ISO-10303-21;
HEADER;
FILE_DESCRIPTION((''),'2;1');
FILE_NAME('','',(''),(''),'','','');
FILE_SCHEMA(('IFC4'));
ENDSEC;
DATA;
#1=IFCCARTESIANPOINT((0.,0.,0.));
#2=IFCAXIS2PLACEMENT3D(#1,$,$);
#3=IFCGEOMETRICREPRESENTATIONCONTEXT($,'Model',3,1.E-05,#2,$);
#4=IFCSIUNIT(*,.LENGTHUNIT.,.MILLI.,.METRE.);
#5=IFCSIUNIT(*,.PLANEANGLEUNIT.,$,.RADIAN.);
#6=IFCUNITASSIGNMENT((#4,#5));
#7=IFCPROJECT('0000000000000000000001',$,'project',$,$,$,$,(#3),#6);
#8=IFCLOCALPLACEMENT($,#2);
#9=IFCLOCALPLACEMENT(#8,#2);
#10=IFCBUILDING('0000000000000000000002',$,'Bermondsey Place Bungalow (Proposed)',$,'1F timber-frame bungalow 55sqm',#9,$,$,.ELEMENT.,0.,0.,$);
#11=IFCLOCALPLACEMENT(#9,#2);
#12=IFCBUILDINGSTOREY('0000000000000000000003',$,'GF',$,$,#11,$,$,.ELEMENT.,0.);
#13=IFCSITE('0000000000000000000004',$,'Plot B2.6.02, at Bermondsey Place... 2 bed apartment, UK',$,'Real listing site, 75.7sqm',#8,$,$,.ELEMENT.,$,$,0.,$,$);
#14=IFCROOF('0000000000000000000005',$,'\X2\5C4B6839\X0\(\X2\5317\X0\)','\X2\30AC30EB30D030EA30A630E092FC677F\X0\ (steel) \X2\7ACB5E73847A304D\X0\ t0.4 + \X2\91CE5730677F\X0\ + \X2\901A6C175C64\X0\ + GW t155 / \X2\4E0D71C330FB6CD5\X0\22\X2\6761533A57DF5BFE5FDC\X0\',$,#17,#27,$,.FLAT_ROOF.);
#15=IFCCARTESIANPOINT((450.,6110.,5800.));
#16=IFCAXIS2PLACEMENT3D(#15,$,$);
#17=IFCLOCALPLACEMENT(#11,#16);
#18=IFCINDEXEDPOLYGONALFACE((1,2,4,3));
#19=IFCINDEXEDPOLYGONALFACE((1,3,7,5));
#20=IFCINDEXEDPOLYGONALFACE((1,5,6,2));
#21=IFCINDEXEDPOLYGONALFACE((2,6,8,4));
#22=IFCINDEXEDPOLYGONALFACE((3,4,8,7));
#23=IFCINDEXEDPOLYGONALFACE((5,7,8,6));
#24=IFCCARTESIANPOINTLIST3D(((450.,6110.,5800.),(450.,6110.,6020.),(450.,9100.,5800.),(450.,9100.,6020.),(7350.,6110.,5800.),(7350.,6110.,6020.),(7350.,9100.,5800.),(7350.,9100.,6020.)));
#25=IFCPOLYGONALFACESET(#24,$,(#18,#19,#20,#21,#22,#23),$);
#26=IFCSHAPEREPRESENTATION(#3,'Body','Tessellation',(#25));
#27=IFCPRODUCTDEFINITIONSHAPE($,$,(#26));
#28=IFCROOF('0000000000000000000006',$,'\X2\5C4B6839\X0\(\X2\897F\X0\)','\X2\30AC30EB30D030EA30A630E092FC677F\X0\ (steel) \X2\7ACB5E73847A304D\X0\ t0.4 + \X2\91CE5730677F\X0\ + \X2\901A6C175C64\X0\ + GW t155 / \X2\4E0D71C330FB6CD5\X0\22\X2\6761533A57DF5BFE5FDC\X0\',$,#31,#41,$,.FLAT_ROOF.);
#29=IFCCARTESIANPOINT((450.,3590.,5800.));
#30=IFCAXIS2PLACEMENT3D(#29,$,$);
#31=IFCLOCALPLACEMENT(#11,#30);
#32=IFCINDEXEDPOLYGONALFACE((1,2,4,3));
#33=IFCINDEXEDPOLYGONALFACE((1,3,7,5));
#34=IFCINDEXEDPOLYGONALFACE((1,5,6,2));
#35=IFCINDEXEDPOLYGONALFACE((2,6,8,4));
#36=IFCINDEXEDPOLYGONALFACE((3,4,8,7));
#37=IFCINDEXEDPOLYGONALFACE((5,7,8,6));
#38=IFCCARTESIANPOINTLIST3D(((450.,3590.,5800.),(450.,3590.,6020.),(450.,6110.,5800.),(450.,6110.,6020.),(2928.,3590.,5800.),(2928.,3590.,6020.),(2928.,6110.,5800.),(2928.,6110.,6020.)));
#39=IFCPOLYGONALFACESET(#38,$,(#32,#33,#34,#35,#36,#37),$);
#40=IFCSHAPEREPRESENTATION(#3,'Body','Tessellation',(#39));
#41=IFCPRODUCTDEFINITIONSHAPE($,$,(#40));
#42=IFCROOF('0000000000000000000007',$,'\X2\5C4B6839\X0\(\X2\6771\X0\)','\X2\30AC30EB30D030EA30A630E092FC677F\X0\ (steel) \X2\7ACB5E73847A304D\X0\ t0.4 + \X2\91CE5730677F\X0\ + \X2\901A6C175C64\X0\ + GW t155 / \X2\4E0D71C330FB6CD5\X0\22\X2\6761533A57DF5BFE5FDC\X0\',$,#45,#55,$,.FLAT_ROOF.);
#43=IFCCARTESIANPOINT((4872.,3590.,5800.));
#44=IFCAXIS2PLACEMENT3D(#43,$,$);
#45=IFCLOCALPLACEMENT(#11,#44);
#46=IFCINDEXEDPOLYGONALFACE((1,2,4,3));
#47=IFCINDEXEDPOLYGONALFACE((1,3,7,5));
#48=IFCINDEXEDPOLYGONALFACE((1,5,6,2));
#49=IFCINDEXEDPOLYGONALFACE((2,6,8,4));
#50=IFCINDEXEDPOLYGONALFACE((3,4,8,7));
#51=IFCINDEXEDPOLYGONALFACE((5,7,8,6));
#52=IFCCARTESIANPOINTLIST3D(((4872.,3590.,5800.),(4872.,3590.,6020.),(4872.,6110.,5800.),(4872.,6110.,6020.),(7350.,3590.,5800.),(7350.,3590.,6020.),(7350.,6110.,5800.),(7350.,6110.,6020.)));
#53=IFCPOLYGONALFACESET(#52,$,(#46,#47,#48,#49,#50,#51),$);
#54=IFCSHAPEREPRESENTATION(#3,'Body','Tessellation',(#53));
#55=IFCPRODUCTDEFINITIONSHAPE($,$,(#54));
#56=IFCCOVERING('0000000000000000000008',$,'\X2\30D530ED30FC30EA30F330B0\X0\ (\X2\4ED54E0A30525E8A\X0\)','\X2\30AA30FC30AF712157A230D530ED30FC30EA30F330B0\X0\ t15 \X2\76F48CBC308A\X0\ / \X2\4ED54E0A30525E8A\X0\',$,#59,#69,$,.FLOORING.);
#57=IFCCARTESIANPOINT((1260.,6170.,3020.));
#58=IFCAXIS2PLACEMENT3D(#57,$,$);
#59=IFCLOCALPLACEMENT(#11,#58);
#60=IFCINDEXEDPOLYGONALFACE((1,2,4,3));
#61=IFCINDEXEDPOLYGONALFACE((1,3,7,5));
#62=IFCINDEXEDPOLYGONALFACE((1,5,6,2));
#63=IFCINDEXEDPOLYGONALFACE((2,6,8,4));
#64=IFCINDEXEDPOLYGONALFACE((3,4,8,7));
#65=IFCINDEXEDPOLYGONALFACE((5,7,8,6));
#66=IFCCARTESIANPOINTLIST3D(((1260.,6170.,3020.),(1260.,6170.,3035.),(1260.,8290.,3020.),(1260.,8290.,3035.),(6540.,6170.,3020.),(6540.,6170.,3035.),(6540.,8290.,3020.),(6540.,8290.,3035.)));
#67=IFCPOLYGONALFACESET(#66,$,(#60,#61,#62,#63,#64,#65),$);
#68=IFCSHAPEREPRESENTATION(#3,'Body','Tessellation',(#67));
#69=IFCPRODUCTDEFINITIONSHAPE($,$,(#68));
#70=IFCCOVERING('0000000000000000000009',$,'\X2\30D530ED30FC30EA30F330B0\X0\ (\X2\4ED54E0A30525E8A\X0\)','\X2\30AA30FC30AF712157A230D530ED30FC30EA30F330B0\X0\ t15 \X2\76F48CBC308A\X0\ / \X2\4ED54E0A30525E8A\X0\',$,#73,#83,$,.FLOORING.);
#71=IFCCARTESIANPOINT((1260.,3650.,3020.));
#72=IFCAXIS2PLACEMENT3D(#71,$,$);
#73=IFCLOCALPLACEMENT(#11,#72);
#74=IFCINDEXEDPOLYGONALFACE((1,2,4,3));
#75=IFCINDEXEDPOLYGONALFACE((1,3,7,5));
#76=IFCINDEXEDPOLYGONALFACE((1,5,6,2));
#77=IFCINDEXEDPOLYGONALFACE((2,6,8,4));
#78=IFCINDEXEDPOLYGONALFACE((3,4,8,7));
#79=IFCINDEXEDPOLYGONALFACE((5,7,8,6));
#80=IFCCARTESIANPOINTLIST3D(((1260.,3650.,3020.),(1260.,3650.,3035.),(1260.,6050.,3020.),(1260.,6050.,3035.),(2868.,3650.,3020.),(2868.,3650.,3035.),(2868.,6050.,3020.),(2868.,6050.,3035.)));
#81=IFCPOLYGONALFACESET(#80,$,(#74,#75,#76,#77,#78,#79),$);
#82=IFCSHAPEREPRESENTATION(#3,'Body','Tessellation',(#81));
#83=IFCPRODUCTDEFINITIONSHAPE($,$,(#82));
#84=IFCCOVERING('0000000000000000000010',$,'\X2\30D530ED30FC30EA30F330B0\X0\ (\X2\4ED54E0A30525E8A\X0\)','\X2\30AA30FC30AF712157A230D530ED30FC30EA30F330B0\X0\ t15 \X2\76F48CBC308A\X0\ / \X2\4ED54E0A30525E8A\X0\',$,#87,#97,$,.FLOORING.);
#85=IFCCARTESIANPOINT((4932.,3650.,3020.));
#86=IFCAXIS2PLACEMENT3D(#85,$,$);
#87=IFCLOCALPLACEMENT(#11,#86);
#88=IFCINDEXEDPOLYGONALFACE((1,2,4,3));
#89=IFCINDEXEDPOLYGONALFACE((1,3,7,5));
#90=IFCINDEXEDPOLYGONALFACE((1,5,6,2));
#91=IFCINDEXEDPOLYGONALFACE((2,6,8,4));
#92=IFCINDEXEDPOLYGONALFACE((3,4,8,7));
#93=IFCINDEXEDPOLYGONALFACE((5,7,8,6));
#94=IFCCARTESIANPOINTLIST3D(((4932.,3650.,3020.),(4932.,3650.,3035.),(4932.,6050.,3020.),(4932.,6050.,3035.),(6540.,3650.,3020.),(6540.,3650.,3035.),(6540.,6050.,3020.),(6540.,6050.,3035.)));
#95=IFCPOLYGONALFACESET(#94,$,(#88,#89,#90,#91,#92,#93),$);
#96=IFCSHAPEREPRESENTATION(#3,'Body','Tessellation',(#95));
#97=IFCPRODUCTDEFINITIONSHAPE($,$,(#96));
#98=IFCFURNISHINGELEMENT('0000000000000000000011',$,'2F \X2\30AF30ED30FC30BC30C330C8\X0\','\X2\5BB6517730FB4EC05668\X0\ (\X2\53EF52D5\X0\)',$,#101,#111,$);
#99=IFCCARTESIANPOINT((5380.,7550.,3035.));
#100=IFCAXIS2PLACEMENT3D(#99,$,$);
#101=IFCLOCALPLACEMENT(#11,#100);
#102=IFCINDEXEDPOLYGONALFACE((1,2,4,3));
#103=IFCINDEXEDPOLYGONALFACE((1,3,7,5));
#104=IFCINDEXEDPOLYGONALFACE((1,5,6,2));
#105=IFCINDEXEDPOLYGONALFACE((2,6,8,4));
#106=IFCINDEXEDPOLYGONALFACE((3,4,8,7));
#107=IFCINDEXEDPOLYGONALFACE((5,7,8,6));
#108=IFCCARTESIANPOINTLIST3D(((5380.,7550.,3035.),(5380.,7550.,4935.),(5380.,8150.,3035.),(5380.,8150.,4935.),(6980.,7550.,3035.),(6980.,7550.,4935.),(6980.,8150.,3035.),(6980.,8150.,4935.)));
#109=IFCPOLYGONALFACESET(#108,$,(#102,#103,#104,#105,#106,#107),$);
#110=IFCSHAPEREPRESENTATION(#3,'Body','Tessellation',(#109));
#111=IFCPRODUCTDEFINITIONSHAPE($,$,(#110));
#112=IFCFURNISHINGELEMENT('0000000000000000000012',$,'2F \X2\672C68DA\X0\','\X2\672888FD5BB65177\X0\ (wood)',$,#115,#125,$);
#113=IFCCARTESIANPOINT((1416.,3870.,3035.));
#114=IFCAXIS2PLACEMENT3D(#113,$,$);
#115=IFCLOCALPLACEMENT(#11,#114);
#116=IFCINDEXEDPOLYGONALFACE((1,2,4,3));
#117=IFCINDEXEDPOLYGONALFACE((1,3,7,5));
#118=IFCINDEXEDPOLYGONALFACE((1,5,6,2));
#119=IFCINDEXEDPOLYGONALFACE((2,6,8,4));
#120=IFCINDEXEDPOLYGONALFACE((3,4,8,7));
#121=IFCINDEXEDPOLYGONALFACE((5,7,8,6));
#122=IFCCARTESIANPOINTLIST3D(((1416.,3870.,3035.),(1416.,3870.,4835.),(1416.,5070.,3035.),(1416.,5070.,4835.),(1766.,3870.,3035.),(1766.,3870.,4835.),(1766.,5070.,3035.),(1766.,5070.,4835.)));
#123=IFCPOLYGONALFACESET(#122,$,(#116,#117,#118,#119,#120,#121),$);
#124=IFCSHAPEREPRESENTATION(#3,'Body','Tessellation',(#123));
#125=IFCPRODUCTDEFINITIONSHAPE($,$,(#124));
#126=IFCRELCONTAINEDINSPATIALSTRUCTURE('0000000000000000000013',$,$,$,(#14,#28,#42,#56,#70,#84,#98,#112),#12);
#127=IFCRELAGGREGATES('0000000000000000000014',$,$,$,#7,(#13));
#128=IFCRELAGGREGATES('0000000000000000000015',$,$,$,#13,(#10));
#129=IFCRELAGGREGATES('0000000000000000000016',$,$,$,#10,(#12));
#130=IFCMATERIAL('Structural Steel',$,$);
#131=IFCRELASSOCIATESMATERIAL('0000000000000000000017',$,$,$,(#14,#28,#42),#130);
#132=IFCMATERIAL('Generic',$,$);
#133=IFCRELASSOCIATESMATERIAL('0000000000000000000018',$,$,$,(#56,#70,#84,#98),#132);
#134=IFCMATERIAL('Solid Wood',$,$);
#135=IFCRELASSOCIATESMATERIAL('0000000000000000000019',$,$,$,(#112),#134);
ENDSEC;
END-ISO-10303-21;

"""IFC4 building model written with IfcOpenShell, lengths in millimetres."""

from ifc_helpers import new_model, si_unit, frame, frame_2d, origin, place, context, project, spatial, rectangle, extrude, material, element, save


model = new_model("IFC4")

# Units and contexts
model_context = context("Model", 3, precision=1e-05, world=origin())
ifc_project = project(units=[si_unit("LENGTHUNIT", "METRE", prefix="MILLI"), si_unit("PLANEANGLEUNIT", "RADIAN")], contexts=[model_context])

# Site, building, storey
site_placement = place(None, origin())
site = spatial("IfcSite", under=ifc_project, at=site_placement, Name="Plot B2.6.02, at Bermondsey Place... 2 bed apartment, UK", ObjectType="Real listing site, 75.7sqm", CompositionType="ELEMENT", RefElevation=0.0)
building_placement = place(site_placement, origin())
building = spatial("IfcBuilding", under=site, at=building_placement, Name="Bermondsey Place Bungalow (Proposed)", ObjectType="1F timber-frame bungalow 55sqm", CompositionType="ELEMENT", ElevationOfRefHeight=0.0, ElevationOfTerrain=0.0)
storey_placement = place(building_placement, origin())
storey = spatial("IfcBuildingStorey", under=building, at=storey_placement, Name="GF", CompositionType="ELEMENT", Elevation=0.0)

# Shared definitions
ifc_material_1 = material(Name="Solid Wood")

# Shared definitions
ifc_material_2 = material(Name="Generic")

# Roofs
ifc_material_3 = material(Name="Structural Steel")
for number, where, name in (
    (1, (450.0, 6110.0, 5800.0), "屋根(北)"),
):
    element("IfcRoof", number, at=place(storey_placement, frame(where)), inside=storey, material=ifc_material_3, Name=name, Description="ガルバリウム鋼板 (steel) 立平葺き t0.4 + 野地板 + 通気層 + GW t155 / 不燃・法22条区域対応", PredefinedType="FLAT_ROOF", context=model_context, shape_type="SweptSolid", body=[
        extrude(rectangle(XDim=6900.0, YDim=2990.0, at=frame_2d((3450.0, 1495.0))), frame((450.0, 6110.0, 5800.0)), (0.0, 0.0, 1.0), 220.0),
    ])
roof_1_placement = place(storey_placement, frame((450.0, 3590.0, 5800.0)))
element("IfcRoof", 2, at=roof_1_placement, inside=storey, material=ifc_material_3, Name="屋根(西)", Description="ガルバリウム鋼板 (steel) 立平葺き t0.4 + 野地板 + 通気層 + GW t155 / 不燃・法22条区域対応", PredefinedType="FLAT_ROOF", context=model_context, shape_type="SweptSolid", body=[
    extrude(rectangle(XDim=2478.0, YDim=2520.0, at=frame_2d((1239.0, 1260.0))), frame((450.0, 3590.0, 5800.0)), (0.0, 0.0, 1.0), 220.0),
])
roof_2_placement = place(storey_placement, frame((4872.0, 3590.0, 5800.0)))
element("IfcRoof", 3, at=roof_2_placement, inside=storey, material=ifc_material_3, Name="屋根(東)", Description="ガルバリウム鋼板 (steel) 立平葺き t0.4 + 野地板 + 通気層 + GW t155 / 不燃・法22条区域対応", PredefinedType="FLAT_ROOF", context=model_context, shape_type="SweptSolid", body=[
    extrude(rectangle(XDim=2478.0, YDim=2520.0, at=frame_2d((1239.0, 1260.0))), frame((4872.0, 3590.0, 5800.0)), (0.0, 0.0, 1.0), 220.0),
])

# Coverings
covering_1_placement = place(storey_placement, frame((1260.0, 6170.0, 3020.0)))
element("IfcCovering", 4, at=covering_1_placement, inside=storey, material=ifc_material_2, Name="フローリング (仕上げ床)", Description="オーク無垢フローリング t15 直貼り / 仕上げ床", PredefinedType="FLOORING", context=model_context, shape_type="SweptSolid", body=[
    extrude(rectangle(XDim=5280.0, YDim=2120.0, at=frame_2d((2640.0, 1060.0))), frame((1260.0, 6170.0, 3020.0)), (0.0, 0.0, 1.0), 15.0),
])
covering_2_placement = place(storey_placement, frame((1260.0, 3650.0, 3020.0)))
element("IfcCovering", 5, at=covering_2_placement, inside=storey, material=ifc_material_2, Name="フローリング (仕上げ床)", Description="オーク無垢フローリング t15 直貼り / 仕上げ床", PredefinedType="FLOORING", context=model_context, shape_type="SweptSolid", body=[
    extrude(rectangle(XDim=1608.0, YDim=2400.0, at=frame_2d((804.0, 1200.0))), frame((1260.0, 3650.0, 3020.0)), (0.0, 0.0, 1.0), 15.0),
])
covering_3_placement = place(storey_placement, frame((4932.0, 3650.0, 3020.0)))
element("IfcCovering", 6, at=covering_3_placement, inside=storey, material=ifc_material_2, Name="フローリング (仕上げ床)", Description="オーク無垢フローリング t15 直貼り / 仕上げ床", PredefinedType="FLOORING", context=model_context, shape_type="SweptSolid", body=[
    extrude(rectangle(XDim=1608.0, YDim=2400.0, at=frame_2d((804.0, 1200.0))), frame((4932.0, 3650.0, 3020.0)), (0.0, 0.0, 1.0), 15.0),
])

# Furnishing elements
furnishing_1_placement = place(storey_placement, frame((5380.0, 7550.0, 3035.0)))
element("IfcFurnishingElement", 7, at=furnishing_1_placement, inside=storey, material=ifc_material_2, Name="2F クローゼット", Description="家具・什器 (可動)", context=model_context, shape_type="SweptSolid", body=[
    extrude(rectangle(XDim=1600.0, YDim=600.0, at=frame_2d((800.0, 300.0))), frame((5380.0, 7550.0, 3035.0)), (0.0, 0.0, 1.0), 1900.0),
])
furnishing_2_placement = place(storey_placement, frame((1416.0, 3870.0, 3035.0)))
element("IfcFurnishingElement", 8, at=furnishing_2_placement, inside=storey, material=ifc_material_1, Name="2F 本棚", Description="木製家具 (wood)", context=model_context, shape_type="SweptSolid", body=[
    extrude(rectangle(XDim=350.0, YDim=1200.0, at=frame_2d((175.0, 600.0))), frame((1416.0, 3870.0, 3035.0)), (0.0, 0.0, 1.0), 1800.0),
])

save(model, "model.ifc")
